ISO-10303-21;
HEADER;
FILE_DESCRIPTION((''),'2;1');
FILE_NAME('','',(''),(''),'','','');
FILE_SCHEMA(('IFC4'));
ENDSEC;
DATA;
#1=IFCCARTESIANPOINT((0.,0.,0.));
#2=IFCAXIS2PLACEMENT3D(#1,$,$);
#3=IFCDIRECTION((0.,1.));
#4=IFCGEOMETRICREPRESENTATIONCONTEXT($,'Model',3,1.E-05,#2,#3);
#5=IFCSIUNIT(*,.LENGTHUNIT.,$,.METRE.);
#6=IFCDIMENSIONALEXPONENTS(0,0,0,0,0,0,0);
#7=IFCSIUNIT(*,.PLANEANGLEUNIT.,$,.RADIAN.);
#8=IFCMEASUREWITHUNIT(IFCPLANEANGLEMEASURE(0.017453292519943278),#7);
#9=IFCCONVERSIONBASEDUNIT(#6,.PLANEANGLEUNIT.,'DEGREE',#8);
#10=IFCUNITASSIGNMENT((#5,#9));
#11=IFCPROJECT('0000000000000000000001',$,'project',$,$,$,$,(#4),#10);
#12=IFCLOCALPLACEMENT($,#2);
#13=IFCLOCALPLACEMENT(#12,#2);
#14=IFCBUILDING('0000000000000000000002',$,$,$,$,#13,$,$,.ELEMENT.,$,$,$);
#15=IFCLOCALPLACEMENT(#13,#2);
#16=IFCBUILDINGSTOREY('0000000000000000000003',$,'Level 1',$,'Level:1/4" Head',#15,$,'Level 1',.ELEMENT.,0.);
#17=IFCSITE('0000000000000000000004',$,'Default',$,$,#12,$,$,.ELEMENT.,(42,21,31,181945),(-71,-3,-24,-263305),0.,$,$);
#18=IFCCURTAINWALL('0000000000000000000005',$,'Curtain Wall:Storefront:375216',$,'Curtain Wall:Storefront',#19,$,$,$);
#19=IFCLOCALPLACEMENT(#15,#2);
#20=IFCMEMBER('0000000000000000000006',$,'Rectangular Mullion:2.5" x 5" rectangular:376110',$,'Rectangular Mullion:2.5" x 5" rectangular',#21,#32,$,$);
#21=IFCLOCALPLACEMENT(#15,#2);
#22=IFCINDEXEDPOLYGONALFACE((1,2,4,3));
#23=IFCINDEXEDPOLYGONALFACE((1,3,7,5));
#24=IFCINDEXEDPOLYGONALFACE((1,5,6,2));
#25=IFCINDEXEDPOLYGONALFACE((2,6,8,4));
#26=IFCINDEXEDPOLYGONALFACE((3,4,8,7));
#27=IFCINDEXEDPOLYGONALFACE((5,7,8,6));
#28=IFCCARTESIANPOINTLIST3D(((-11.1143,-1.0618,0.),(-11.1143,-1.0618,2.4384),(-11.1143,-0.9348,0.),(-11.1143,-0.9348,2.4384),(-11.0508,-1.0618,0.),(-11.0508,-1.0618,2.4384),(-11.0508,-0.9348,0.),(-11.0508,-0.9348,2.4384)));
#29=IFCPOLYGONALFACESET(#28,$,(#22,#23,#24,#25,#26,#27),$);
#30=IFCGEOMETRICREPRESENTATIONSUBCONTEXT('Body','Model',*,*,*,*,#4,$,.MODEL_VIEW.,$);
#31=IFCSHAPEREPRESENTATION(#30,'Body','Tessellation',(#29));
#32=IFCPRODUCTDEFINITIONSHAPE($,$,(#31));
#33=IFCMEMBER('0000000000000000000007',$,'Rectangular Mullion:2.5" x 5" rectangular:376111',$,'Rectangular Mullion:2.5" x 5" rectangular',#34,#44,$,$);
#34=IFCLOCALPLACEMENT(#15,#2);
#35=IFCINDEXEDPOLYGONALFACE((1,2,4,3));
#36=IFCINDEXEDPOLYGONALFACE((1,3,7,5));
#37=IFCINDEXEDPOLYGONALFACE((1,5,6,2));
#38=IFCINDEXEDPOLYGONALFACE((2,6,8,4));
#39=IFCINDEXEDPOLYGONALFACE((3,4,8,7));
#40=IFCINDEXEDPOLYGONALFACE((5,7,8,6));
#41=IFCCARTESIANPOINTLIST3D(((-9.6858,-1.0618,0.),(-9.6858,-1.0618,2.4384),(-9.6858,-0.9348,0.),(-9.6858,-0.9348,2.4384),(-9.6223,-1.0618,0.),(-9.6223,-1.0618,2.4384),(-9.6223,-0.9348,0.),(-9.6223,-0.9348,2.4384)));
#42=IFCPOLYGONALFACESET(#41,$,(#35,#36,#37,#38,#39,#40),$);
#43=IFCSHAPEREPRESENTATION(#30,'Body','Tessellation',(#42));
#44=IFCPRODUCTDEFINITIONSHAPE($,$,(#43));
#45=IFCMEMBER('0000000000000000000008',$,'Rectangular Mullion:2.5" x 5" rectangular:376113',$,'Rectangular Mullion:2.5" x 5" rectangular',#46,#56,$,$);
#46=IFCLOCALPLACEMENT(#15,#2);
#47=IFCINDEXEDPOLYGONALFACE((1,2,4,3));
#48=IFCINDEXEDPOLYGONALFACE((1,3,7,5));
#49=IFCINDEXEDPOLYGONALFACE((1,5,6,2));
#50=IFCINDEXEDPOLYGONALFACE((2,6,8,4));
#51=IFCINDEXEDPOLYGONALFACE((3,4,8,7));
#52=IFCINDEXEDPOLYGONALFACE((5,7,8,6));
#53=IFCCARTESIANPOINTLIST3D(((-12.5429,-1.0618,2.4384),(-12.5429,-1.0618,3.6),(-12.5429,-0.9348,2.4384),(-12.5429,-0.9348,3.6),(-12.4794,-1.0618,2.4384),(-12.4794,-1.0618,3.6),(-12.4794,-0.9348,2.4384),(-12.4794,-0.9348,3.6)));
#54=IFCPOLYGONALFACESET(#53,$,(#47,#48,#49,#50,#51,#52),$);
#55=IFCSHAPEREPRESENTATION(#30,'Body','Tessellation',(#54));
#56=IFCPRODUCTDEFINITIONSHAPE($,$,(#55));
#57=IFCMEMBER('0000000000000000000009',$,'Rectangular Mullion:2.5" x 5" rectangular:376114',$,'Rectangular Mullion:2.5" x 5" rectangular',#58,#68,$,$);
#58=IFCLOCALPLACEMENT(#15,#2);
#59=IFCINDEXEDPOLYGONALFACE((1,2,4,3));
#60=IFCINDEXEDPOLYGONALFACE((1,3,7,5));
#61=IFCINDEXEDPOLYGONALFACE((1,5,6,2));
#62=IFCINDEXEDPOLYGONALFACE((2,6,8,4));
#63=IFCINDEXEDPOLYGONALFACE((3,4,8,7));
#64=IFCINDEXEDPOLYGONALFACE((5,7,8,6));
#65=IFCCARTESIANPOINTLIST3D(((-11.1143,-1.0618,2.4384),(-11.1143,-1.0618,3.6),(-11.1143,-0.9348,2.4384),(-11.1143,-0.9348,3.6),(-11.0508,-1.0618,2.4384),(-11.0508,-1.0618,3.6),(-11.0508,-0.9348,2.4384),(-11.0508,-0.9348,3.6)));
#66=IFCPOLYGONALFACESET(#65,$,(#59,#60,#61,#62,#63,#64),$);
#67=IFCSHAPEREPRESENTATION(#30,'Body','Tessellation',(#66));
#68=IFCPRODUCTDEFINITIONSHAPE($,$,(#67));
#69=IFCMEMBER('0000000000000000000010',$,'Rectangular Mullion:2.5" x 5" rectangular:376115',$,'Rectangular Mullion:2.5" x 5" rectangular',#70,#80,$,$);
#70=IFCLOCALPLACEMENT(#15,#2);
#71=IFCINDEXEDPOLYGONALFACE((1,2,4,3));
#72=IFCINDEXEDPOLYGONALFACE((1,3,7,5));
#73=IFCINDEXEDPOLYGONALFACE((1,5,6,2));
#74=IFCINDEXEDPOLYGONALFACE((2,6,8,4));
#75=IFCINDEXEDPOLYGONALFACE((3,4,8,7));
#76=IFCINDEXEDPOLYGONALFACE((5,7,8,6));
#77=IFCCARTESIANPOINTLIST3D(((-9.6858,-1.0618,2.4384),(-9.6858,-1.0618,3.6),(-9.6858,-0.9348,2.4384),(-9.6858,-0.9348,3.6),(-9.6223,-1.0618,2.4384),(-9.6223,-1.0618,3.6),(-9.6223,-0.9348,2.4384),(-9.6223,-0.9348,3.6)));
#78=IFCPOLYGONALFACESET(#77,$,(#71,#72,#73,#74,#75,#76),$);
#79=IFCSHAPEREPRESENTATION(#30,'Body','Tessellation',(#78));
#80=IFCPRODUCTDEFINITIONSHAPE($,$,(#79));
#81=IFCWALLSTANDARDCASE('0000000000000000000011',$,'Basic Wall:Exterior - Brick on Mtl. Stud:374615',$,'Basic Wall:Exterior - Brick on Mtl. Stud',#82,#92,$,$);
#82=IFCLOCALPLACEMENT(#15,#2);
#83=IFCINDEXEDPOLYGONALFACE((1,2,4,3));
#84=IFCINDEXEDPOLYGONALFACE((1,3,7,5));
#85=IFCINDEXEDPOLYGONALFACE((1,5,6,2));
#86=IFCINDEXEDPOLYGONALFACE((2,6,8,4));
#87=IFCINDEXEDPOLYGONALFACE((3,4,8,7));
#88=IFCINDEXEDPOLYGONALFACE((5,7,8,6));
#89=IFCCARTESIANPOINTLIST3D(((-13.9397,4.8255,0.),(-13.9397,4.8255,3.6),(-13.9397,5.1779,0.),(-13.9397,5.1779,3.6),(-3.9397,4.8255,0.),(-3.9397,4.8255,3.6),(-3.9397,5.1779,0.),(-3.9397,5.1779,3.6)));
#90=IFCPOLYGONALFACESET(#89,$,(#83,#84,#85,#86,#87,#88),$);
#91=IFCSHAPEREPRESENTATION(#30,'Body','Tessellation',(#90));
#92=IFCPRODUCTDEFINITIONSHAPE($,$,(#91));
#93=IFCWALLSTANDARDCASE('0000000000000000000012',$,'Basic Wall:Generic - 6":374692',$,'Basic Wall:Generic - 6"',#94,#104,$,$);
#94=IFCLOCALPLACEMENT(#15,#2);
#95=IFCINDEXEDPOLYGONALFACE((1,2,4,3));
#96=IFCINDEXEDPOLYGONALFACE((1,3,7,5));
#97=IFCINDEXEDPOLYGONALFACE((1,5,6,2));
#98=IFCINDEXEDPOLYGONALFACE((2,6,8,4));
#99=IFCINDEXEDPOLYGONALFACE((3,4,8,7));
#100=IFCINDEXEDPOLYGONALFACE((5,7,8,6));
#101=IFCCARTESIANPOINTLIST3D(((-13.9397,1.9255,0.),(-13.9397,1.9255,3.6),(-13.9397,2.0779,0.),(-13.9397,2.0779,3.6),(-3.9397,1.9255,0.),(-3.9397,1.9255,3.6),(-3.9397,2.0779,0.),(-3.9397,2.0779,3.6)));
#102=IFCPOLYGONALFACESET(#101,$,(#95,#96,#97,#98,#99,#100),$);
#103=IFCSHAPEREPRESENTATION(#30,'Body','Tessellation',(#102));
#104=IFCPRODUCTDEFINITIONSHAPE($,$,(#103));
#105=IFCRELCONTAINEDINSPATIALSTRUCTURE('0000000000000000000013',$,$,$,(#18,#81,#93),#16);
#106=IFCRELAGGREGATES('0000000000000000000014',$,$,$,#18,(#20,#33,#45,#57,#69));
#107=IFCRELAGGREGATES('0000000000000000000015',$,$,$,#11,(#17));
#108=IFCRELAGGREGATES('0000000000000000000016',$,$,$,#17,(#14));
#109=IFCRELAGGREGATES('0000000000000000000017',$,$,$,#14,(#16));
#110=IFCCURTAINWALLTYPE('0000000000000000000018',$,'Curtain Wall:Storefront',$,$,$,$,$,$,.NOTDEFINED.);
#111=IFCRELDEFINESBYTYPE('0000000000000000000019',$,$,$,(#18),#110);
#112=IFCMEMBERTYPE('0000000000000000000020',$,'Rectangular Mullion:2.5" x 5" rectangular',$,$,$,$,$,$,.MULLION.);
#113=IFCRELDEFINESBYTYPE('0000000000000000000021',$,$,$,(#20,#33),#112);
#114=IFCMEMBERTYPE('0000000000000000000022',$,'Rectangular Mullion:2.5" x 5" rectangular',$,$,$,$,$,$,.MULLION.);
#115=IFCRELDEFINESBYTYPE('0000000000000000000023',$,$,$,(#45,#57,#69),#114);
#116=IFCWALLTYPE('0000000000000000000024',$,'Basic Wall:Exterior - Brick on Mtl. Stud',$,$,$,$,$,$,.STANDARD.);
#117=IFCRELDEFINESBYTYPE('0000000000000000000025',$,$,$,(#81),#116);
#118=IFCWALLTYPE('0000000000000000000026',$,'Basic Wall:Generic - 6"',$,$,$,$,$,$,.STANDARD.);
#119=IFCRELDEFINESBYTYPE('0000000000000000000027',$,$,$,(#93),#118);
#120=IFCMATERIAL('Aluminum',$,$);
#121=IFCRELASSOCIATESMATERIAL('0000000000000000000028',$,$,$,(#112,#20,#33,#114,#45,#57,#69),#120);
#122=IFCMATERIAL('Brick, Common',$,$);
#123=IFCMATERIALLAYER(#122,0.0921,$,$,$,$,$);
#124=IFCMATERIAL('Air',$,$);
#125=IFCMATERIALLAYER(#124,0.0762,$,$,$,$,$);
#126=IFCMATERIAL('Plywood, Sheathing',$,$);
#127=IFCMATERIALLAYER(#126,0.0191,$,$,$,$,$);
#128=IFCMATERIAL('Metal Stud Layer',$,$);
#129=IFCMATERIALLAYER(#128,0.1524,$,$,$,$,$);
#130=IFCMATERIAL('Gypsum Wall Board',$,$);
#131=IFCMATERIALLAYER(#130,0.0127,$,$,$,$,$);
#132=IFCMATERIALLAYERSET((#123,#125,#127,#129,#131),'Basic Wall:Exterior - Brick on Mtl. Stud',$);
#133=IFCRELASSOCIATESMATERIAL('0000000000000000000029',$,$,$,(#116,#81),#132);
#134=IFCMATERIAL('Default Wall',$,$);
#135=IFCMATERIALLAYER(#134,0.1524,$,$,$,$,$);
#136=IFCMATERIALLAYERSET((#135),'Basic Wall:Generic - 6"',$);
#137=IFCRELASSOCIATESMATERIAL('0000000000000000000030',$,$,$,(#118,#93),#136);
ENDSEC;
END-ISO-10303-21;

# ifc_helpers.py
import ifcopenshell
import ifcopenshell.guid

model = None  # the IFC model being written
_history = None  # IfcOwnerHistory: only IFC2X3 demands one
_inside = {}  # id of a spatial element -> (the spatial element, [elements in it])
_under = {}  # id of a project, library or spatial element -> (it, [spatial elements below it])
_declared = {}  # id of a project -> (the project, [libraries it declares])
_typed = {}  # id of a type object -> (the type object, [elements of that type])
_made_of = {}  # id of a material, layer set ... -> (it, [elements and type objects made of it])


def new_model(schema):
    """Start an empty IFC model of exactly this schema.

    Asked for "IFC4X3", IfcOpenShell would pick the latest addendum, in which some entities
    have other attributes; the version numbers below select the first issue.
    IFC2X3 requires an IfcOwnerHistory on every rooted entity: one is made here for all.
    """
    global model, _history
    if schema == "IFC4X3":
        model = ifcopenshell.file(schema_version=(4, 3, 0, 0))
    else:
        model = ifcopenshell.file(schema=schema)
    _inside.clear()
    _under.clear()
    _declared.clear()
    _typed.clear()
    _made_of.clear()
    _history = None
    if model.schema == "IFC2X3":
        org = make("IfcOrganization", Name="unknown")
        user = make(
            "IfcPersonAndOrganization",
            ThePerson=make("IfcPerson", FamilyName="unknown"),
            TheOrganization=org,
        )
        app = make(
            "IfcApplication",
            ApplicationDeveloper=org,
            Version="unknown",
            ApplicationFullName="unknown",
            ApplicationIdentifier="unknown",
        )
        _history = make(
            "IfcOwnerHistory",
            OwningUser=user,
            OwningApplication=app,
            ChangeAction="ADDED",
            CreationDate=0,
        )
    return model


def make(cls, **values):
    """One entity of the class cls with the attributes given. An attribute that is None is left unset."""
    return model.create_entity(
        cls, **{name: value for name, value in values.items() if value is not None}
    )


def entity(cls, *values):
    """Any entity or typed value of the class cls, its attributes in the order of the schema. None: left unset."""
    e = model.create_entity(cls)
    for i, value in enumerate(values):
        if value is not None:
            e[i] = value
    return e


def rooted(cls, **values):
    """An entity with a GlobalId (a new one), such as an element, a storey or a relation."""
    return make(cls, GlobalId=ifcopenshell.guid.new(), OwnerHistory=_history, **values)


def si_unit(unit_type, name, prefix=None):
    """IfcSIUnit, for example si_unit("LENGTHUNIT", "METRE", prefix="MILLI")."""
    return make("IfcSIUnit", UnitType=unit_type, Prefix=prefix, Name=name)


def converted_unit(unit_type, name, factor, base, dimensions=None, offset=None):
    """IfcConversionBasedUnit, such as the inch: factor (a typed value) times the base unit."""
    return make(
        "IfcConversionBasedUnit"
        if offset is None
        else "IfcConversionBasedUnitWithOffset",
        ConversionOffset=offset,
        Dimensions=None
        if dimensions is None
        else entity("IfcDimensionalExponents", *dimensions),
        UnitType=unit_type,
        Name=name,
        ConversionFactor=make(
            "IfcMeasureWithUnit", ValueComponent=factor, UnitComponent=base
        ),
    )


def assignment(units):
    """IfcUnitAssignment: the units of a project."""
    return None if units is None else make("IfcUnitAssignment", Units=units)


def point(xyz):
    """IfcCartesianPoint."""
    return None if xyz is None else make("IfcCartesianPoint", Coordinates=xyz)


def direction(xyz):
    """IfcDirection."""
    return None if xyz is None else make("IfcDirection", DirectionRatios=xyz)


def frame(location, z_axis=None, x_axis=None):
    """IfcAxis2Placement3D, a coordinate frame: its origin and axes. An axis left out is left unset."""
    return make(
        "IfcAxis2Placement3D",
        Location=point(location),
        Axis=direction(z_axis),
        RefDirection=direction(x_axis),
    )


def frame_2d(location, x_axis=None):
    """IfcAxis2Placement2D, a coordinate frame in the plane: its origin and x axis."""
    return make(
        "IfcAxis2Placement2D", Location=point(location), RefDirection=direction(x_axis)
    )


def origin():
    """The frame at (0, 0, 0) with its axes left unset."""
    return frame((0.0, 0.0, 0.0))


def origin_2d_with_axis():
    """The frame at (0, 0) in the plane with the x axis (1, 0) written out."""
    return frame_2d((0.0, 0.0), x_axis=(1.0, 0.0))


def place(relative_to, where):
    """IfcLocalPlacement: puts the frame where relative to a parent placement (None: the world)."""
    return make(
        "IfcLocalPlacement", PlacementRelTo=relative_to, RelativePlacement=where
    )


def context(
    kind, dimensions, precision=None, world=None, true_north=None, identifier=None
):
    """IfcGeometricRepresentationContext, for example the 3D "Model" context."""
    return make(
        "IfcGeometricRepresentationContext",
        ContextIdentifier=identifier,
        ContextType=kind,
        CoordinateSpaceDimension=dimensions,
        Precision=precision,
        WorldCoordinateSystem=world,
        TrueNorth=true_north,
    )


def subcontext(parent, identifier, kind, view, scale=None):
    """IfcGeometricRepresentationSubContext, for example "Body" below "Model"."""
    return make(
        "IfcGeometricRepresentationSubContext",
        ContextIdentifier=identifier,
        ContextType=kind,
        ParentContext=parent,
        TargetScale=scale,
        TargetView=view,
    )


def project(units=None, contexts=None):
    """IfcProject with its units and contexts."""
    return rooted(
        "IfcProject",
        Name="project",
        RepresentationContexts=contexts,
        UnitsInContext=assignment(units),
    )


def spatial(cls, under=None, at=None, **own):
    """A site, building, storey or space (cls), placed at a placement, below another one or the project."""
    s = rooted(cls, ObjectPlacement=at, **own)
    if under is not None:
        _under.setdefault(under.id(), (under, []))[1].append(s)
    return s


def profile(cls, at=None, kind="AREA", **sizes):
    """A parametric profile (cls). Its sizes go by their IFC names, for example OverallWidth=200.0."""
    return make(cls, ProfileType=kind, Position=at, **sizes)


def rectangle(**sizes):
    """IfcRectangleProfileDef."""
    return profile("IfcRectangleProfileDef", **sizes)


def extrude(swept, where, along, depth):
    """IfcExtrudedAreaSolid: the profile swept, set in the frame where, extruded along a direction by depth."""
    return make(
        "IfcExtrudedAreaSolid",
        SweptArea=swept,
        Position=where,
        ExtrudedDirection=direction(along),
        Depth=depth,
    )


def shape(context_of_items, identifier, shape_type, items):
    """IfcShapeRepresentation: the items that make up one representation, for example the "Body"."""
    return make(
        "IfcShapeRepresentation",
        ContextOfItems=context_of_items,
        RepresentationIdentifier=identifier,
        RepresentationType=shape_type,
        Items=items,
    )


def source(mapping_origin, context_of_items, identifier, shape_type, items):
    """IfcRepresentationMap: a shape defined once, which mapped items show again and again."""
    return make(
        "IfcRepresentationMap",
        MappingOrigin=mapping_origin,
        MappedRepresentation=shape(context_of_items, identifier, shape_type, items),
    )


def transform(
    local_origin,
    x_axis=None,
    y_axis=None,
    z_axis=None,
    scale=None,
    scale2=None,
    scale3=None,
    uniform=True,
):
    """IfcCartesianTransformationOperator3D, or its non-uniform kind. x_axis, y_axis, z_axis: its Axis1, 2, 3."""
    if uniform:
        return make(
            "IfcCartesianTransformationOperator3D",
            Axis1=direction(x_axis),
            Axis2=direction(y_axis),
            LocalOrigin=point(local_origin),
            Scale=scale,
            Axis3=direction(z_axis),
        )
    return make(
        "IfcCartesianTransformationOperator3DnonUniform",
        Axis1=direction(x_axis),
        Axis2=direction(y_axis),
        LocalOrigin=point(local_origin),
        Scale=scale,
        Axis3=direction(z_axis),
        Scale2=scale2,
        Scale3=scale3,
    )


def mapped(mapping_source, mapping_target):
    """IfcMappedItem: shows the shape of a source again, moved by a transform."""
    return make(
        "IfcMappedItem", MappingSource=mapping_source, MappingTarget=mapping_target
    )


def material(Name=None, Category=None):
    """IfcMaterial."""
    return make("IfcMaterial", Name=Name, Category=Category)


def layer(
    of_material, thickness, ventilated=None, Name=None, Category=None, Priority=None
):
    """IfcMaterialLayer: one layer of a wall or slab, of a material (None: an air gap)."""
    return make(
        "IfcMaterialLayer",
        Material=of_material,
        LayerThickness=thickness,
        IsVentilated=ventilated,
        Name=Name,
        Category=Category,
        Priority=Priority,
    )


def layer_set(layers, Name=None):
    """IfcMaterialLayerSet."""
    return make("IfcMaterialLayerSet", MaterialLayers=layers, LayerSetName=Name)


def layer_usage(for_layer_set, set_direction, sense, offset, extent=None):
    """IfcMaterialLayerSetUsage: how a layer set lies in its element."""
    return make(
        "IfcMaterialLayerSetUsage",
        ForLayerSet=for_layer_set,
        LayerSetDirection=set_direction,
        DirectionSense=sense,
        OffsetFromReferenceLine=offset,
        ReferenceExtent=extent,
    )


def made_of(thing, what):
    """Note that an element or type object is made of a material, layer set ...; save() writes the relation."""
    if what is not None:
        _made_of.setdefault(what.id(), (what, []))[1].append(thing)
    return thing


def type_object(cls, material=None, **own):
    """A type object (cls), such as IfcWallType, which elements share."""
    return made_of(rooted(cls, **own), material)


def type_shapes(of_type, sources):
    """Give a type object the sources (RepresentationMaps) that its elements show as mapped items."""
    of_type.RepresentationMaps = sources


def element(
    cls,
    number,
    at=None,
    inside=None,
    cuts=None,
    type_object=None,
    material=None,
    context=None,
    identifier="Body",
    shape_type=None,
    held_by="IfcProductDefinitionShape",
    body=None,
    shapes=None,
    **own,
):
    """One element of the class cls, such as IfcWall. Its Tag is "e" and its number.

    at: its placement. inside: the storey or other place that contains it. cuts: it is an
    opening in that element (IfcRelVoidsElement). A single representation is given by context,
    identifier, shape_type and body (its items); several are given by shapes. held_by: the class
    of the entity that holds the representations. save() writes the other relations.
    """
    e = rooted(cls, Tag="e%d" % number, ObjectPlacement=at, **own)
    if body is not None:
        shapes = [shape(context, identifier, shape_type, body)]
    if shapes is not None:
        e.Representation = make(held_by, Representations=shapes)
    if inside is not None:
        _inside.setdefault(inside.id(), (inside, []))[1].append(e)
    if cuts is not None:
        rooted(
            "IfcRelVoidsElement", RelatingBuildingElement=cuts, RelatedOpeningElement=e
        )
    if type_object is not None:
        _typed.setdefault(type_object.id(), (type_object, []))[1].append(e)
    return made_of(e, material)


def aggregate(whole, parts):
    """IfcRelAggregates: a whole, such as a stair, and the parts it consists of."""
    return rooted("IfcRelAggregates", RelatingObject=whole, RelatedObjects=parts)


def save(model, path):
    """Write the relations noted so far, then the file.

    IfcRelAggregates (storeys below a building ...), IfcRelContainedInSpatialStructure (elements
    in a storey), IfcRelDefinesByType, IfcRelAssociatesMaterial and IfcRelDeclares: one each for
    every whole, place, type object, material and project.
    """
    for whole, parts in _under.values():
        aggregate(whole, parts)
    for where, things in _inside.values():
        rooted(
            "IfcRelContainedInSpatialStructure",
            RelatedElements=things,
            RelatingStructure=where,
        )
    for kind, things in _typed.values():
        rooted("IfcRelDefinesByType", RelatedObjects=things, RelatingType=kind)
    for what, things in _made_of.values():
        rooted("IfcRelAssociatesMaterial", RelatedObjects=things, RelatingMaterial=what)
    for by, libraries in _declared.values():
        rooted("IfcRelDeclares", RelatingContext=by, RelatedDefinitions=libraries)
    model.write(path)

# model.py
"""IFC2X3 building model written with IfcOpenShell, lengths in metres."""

from ifc_helpers import new_model, entity, si_unit, converted_unit, direction, frame, frame_2d, origin, origin_2d_with_axis, place, context, subcontext, project, spatial, rectangle, extrude, source, transform, mapped, material, layer, layer_set, layer_usage, type_object, type_shapes, element, aggregate, save


model = new_model("IFC2X3")

# Units and contexts
model_context = context("Model", 3, precision=1e-05, world=origin(), true_north=direction((0.0, 1.0)))
body_context = subcontext(model_context, "Body", "Model", "MODEL_VIEW")
ifc_project = project(units=[si_unit("LENGTHUNIT", "METRE"), converted_unit("PLANEANGLEUNIT", "DEGREE", entity("IfcPlaneAngleMeasure", 0.017453292519943278), si_unit("PLANEANGLEUNIT", "RADIAN"), dimensions=[0, 0, 0, 0, 0, 0, 0])], contexts=[model_context])

# Site, building, storey
site_placement = place(None, origin())
site = spatial("IfcSite", under=ifc_project, at=site_placement, Name="Default", CompositionType="ELEMENT", RefLatitude=(42, 21, 31, 181945), RefLongitude=(-71, -3, -24, -263305), RefElevation=0.0)
building_placement = place(site_placement, origin())
building = spatial("IfcBuilding", under=site, at=building_placement, CompositionType="ELEMENT")
storey_placement = place(building_placement, origin())
storey = spatial("IfcBuildingStorey", under=building, at=storey_placement, Name="Level 1", ObjectType="Level:1/4\" Head", LongName="Level 1", CompositionType="ELEMENT", Elevation=0.0)

# Curtain wall, members
curtain_wall_type = type_object("IfcCurtainWallType", Name="Curtain Wall:Storefront", PredefinedType="NOTDEFINED")
curtain_wall_placement = place(storey_placement, origin())
curtain_wall = element("IfcCurtainWall", 1, at=curtain_wall_placement, inside=storey, type_object=curtain_wall_type, Name="Curtain Wall:Storefront:375216", ObjectType="Curtain Wall:Storefront")
ifc_material_1 = material(Name="Aluminum")
member_type_1 = type_object("IfcMemberType", Name="Rectangular Mullion:2.5\" x 5\" rectangular", PredefinedType="MULLION", material=ifc_material_1)
shared_shape_1 = source(origin(), body_context, "Body", "SweptSolid", [
    extrude(rectangle(XDim=0.0635, YDim=0.127, at=origin_2d_with_axis()), frame((0.0, 0.0, -2.4384), z_axis=(0.0, 0.0, 1.0), x_axis=(-1.0, 0.0, 0.0)), (0.0, 0.0, 1.0), 2.4384),
])
type_shapes(member_type_1, [shared_shape_1])
member_1_placement = place(curtain_wall_placement, frame((-11.0826, -0.9983, 0.0), z_axis=(0.0, 0.0, -1.0), x_axis=(1.0, 0.0, 0.0)))
member_1 = element("IfcMember", 2, at=member_1_placement, type_object=member_type_1, material=ifc_material_1, Name="Rectangular Mullion:2.5\" x 5\" rectangular:376110", ObjectType="Rectangular Mullion:2.5\" x 5\" rectangular", context=body_context, shape_type="MappedRepresentation", body=[
    mapped(shared_shape_1, transform((0.0, 0.0, 0.0), scale=1.0)),
])
member_2_placement = place(curtain_wall_placement, frame((-9.654, -0.9983, 0.0), z_axis=(0.0, 0.0, -1.0), x_axis=(1.0, 0.0, 0.0)))
member_2 = element("IfcMember", 3, at=member_2_placement, type_object=member_type_1, material=ifc_material_1, Name="Rectangular Mullion:2.5\" x 5\" rectangular:376111", ObjectType="Rectangular Mullion:2.5\" x 5\" rectangular", context=body_context, shape_type="MappedRepresentation", body=[
    mapped(shared_shape_1, transform((0.0, 0.0, 0.0), scale=1.0)),
])
member_type_2 = type_object("IfcMemberType", Name="Rectangular Mullion:2.5\" x 5\" rectangular", PredefinedType="MULLION", material=ifc_material_1)
shared_shape_2 = source(origin(), body_context, "Body", "SweptSolid", [
    extrude(rectangle(XDim=0.0635, YDim=0.127, at=origin_2d_with_axis()), frame((0.0, 0.0, -1.1616), z_axis=(0.0, 0.0, 1.0), x_axis=(-1.0, 0.0, 0.0)), (0.0, 0.0, 1.0), 1.1616),
])
type_shapes(member_type_2, [shared_shape_2])
member_3_placement = place(curtain_wall_placement, frame((-12.5112, -0.9983, 2.4384), z_axis=(0.0, 0.0, -1.0), x_axis=(1.0, 0.0, 0.0)))
member_3 = element("IfcMember", 4, at=member_3_placement, type_object=member_type_2, material=ifc_material_1, Name="Rectangular Mullion:2.5\" x 5\" rectangular:376113", ObjectType="Rectangular Mullion:2.5\" x 5\" rectangular", context=body_context, shape_type="MappedRepresentation", body=[
    mapped(shared_shape_2, transform((0.0, 0.0, 0.0), scale=1.0)),
])
member_4_placement = place(curtain_wall_placement, frame((-11.0826, -0.9983, 2.4384), z_axis=(0.0, 0.0, -1.0), x_axis=(1.0, 0.0, 0.0)))
member_4 = element("IfcMember", 5, at=member_4_placement, type_object=member_type_2, material=ifc_material_1, Name="Rectangular Mullion:2.5\" x 5\" rectangular:376114", ObjectType="Rectangular Mullion:2.5\" x 5\" rectangular", context=body_context, shape_type="MappedRepresentation", body=[
    mapped(shared_shape_2, transform((0.0, 0.0, 0.0), scale=1.0)),
])
member_5_placement = place(curtain_wall_placement, frame((-9.654, -0.9983, 2.4384), z_axis=(0.0, 0.0, -1.0), x_axis=(1.0, 0.0, 0.0)))
member_5 = element("IfcMember", 6, at=member_5_placement, type_object=member_type_2, material=ifc_material_1, Name="Rectangular Mullion:2.5\" x 5\" rectangular:376115", ObjectType="Rectangular Mullion:2.5\" x 5\" rectangular", context=body_context, shape_type="MappedRepresentation", body=[
    mapped(shared_shape_2, transform((0.0, 0.0, 0.0), scale=1.0)),
])
aggregate(curtain_wall, [member_1, member_2, member_3, member_4, member_5])

# Walls
ifc_material_2 = material(Name="Brick, Common")
ifc_layer_1 = layer(ifc_material_2, 0.0921)
ifc_material_3 = material(Name="Air")
ifc_layer_2 = layer(ifc_material_3, 0.0762)
ifc_material_4 = material(Name="Plywood, Sheathing")
ifc_layer_3 = layer(ifc_material_4, 0.0191)
ifc_material_5 = material(Name="Metal Stud Layer")
ifc_layer_4 = layer(ifc_material_5, 0.1524)
ifc_material_6 = material(Name="Gypsum Wall Board")
ifc_layer_5 = layer(ifc_material_6, 0.0127)
ifc_layer_set_1 = layer_set([ifc_layer_1, ifc_layer_2, ifc_layer_3, ifc_layer_4, ifc_layer_5], Name="Basic Wall:Exterior - Brick on Mtl. Stud")
ifc_layer_usage_1 = layer_usage(ifc_layer_set_1, "AXIS2", "NEGATIVE", 0.1762)
wall_type_1 = type_object("IfcWallType", Name="Basic Wall:Exterior - Brick on Mtl. Stud", PredefinedType="STANDARD", material=ifc_layer_set_1)
wall_1_placement = place(storey_placement, frame((-13.9397, 5.0017, 0.0)))
element("IfcWallStandardCase", 7, at=wall_1_placement, inside=storey, type_object=wall_type_1, material=ifc_layer_usage_1, Name="Basic Wall:Exterior - Brick on Mtl. Stud:374615", ObjectType="Basic Wall:Exterior - Brick on Mtl. Stud", context=body_context, shape_type="SweptSolid", body=[
    extrude(rectangle(XDim=10.0, YDim=0.3524, at=frame_2d((5.0, 0.0), x_axis=(-1.0, 0.0))), origin(), (0.0, 0.0, 1.0), 3.6),
])
ifc_material_7 = material(Name="Default Wall")
ifc_layer_6 = layer(ifc_material_7, 0.1524)
ifc_layer_set_2 = layer_set([ifc_layer_6], Name="Basic Wall:Generic - 6\"")
ifc_layer_usage_2 = layer_usage(ifc_layer_set_2, "AXIS2", "NEGATIVE", 0.0762)
wall_type_2 = type_object("IfcWallType", Name="Basic Wall:Generic - 6\"", PredefinedType="STANDARD", material=ifc_layer_set_2)
wall_2_placement = place(storey_placement, frame((-13.9397, 2.0017, 0.0)))
element("IfcWallStandardCase", 8, at=wall_2_placement, inside=storey, type_object=wall_type_2, material=ifc_layer_usage_2, Name="Basic Wall:Generic - 6\":374692", ObjectType="Basic Wall:Generic - 6\"", context=body_context, shape_type="SweptSolid", body=[
    extrude(rectangle(XDim=10.0, YDim=0.1524, at=frame_2d((5.0, 0.0), x_axis=(-1.0, 0.0))), origin(), (0.0, 0.0, 1.0), 3.6),
])

save(model, "model.ifc")
